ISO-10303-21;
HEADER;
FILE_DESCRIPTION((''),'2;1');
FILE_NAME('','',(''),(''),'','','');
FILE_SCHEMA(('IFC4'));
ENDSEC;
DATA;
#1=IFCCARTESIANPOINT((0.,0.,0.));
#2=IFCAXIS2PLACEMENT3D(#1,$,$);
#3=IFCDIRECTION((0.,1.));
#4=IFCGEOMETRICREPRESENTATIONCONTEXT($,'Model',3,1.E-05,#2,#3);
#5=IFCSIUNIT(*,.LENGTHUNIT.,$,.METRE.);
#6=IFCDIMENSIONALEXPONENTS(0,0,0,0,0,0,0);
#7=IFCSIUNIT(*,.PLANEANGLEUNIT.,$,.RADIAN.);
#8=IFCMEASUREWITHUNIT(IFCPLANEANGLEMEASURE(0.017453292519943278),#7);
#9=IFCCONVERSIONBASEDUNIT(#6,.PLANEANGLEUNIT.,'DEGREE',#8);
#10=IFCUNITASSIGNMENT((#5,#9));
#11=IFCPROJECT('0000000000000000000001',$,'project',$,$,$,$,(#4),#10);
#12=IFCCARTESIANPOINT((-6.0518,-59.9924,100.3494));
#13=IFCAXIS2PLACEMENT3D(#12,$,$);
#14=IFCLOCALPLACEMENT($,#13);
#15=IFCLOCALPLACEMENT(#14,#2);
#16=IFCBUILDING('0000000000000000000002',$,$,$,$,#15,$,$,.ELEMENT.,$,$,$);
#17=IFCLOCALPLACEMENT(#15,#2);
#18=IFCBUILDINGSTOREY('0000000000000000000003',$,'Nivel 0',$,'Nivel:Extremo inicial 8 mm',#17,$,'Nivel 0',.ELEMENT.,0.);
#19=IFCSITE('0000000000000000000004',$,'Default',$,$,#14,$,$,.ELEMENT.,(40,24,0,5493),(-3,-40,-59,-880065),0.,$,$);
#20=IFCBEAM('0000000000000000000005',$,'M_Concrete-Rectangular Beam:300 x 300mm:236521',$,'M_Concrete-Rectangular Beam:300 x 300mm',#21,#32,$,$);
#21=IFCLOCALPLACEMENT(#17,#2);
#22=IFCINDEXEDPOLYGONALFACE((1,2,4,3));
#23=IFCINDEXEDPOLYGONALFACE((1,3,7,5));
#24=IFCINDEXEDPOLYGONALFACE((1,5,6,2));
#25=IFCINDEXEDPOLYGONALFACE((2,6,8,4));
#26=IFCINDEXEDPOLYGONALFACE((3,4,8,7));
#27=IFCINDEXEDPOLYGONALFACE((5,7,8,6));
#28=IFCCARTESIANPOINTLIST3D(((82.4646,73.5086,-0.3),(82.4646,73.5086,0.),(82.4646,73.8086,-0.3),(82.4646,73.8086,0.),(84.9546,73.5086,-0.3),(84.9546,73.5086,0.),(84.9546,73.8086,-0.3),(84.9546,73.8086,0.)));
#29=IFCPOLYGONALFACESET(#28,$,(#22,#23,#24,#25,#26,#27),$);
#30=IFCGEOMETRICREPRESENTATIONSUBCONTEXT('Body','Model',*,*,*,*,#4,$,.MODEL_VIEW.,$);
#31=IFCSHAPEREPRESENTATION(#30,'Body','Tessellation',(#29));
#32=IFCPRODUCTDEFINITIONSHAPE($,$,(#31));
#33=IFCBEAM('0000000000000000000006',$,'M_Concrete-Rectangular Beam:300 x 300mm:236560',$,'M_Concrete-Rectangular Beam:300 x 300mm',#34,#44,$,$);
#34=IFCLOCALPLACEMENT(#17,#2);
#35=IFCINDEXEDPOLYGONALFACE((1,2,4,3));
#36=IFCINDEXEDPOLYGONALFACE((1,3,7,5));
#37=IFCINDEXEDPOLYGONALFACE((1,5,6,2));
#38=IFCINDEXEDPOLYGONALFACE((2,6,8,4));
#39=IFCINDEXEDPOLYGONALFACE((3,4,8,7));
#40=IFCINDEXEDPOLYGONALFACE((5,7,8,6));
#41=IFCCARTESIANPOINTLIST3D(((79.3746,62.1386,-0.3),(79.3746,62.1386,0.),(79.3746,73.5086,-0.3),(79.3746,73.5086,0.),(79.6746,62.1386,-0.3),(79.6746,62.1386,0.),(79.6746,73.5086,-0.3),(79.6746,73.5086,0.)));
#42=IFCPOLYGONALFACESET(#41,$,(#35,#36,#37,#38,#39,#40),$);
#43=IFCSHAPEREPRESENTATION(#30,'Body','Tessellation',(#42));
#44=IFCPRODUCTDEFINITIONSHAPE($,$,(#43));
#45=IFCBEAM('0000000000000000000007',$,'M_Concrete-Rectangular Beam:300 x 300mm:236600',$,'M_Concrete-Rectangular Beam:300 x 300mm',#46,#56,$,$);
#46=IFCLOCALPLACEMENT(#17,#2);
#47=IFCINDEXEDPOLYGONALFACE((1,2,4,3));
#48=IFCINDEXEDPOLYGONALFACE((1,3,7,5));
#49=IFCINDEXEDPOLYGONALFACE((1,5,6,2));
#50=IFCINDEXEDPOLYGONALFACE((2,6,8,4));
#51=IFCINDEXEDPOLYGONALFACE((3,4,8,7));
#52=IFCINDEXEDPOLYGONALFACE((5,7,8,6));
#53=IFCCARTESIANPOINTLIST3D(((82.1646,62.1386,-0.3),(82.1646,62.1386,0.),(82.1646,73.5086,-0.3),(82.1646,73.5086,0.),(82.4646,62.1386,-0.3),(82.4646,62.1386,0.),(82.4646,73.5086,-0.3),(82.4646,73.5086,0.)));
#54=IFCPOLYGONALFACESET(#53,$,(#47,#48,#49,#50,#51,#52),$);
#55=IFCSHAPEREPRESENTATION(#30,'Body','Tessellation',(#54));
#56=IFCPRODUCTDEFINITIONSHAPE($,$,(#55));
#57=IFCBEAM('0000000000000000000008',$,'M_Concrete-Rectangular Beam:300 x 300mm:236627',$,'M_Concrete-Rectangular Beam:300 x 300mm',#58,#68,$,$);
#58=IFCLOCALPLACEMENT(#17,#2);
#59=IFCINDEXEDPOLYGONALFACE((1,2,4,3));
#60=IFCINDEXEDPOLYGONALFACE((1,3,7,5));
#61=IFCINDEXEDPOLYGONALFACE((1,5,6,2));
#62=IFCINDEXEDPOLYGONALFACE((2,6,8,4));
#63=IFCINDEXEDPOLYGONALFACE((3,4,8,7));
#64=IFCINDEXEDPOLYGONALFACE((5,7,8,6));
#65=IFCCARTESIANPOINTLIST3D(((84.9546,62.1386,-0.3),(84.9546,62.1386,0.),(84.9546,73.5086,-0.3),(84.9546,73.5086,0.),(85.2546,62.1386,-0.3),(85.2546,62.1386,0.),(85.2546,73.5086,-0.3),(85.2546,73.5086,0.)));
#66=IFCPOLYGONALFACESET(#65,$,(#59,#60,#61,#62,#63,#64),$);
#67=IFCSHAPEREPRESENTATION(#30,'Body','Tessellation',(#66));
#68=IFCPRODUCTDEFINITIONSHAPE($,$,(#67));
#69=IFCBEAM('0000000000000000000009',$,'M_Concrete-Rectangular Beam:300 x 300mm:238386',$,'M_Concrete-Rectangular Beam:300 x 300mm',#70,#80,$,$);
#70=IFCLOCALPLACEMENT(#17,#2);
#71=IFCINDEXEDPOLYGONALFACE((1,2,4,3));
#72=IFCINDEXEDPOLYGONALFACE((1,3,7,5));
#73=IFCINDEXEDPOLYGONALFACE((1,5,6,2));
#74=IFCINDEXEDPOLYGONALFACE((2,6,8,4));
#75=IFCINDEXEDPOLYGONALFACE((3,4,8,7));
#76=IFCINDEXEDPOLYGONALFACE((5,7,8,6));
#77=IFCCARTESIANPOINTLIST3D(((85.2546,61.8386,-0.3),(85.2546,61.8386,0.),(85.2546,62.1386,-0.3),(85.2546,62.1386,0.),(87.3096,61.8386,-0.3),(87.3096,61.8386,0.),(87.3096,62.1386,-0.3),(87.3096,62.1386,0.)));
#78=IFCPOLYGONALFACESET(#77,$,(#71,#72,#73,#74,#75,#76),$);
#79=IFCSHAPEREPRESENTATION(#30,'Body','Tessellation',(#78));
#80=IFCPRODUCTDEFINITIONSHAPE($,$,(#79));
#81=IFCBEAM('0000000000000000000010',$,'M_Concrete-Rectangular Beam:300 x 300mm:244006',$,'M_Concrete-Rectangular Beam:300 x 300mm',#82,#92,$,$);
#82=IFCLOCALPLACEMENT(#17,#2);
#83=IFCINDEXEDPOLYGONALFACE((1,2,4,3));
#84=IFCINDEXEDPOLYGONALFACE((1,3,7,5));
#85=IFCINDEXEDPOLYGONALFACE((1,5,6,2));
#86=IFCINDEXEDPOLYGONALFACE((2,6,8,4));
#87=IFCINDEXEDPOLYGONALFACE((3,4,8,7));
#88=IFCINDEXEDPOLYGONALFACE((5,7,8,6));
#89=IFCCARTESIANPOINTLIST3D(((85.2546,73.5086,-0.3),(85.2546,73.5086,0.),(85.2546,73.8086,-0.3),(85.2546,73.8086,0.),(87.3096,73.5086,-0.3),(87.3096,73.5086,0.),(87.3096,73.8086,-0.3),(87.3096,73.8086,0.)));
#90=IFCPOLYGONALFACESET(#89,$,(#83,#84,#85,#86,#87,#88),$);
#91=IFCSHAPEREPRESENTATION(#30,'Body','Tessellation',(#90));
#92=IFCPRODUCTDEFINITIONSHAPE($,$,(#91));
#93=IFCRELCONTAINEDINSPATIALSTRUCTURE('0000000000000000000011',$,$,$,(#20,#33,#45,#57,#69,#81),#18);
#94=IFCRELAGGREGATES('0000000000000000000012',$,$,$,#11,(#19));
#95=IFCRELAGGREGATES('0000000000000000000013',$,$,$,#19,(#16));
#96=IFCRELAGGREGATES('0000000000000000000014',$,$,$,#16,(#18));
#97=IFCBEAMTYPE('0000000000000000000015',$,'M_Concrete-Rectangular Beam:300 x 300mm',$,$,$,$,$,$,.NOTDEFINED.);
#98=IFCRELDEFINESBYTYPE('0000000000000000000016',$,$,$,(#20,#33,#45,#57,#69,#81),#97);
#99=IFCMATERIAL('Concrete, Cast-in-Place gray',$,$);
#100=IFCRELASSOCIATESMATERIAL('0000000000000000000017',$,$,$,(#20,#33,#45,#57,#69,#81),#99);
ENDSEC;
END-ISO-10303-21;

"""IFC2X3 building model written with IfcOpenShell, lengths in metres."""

from ifc_helpers import new_model, entity, si_unit, converted_unit, direction, frame, frame_2d, origin, place, context, subcontext, project, spatial, rectangle, extrude, material, type_object, element, save


model = new_model("IFC2X3")

# Units and contexts
model_context = context("Model", 3, precision=1e-05, world=origin(), true_north=direction((0.0, 1.0)))
body_context = subcontext(model_context, "Body", "Model", "MODEL_VIEW")
ifc_project = project(units=[si_unit("LENGTHUNIT", "METRE"), converted_unit("PLANEANGLEUNIT", "DEGREE", entity("IfcPlaneAngleMeasure", 0.017453292519943278), si_unit("PLANEANGLEUNIT", "RADIAN"), dimensions=[0, 0, 0, 0, 0, 0, 0])], contexts=[model_context])

# Site, building, storey
site_placement = place(None, frame((-6.0518, -59.9924, 100.3494)))
site = spatial("IfcSite", under=ifc_project, at=site_placement, Name="Default", CompositionType="ELEMENT", RefLatitude=(40, 24, 0, 5493), RefLongitude=(-3, -40, -59, -880065), RefElevation=0.0)
building_placement = place(site_placement, origin())
building = spatial("IfcBuilding", under=site, at=building_placement, CompositionType="ELEMENT")
storey_placement = place(building_placement, origin())
storey = spatial("IfcBuildingStorey", under=building, at=storey_placement, Name="Nivel 0", ObjectType="Nivel:Extremo inicial 8 mm", LongName="Nivel 0", CompositionType="ELEMENT", Elevation=0.0)

# Shared definitions
ifc_material = material(Name="Concrete, Cast-in-Place gray")

# Beams
beam_type = type_object("IfcBeamType", Name="M_Concrete-Rectangular Beam:300 x 300mm", PredefinedType="NOTDEFINED")
for number, where, name in (
    (1, (82.3146, 73.6586, 0.0), "M_Concrete-Rectangular Beam:300 x 300mm:236521"),
):
    element("IfcBeam", number, at=place(storey_placement, frame(where)), inside=storey, type_object=beam_type, material=ifc_material, Name=name, ObjectType="M_Concrete-Rectangular Beam:300 x 300mm", context=body_context, shape_type="SweptSolid", body=[
        extrude(rectangle(XDim=0.3, YDim=0.3, at=frame_2d((0.0, 0.0), x_axis=(1.0, 0.0))), frame((0.15, 0.0, -0.15), z_axis=(1.0, 0.0, 0.0), x_axis=(0.0, 0.0, -1.0)), (0.0, 0.0, 1.0), 2.49),
    ])
beam_1_placement = place(storey_placement, frame((79.5246, 73.6586, 0.0), z_axis=(0.0, 0.0, 1.0), x_axis=(0.0, -1.0, 0.0)))
element("IfcBeam", 2, at=beam_1_placement, inside=storey, type_object=beam_type, material=ifc_material, Name="M_Concrete-Rectangular Beam:300 x 300mm:236560", ObjectType="M_Concrete-Rectangular Beam:300 x 300mm", context=body_context, shape_type="SweptSolid", body=[
    extrude(rectangle(XDim=0.3, YDim=0.3, at=frame_2d((0.0, 0.0), x_axis=(1.0, 0.0))), frame((0.15, 0.0, -0.15), z_axis=(1.0, 0.0, 0.0), x_axis=(0.0, 0.0, -1.0)), (0.0, 0.0, 1.0), 11.37),
])
beam_2_placement = place(storey_placement, frame((82.3146, 61.9886, 0.0), z_axis=(0.0, 0.0, 1.0), x_axis=(0.0, 1.0, 0.0)))
element("IfcBeam", 3, at=beam_2_placement, inside=storey, type_object=beam_type, material=ifc_material, Name="M_Concrete-Rectangular Beam:300 x 300mm:236600", ObjectType="M_Concrete-Rectangular Beam:300 x 300mm", context=body_context, shape_type="SweptSolid", body=[
    extrude(rectangle(XDim=0.3, YDim=0.3, at=frame_2d((0.0, 0.0), x_axis=(1.0, 0.0))), frame((0.15, 0.0, -0.15), z_axis=(1.0, 0.0, 0.0), x_axis=(0.0, 0.0, -1.0)), (0.0, 0.0, 1.0), 11.37),
])
beam_3_placement = place(storey_placement, frame((85.1046, 73.6586, 0.0), z_axis=(0.0, 0.0, 1.0), x_axis=(0.0, -1.0, 0.0)))
element("IfcBeam", 4, at=beam_3_placement, inside=storey, type_object=beam_type, material=ifc_material, Name="M_Concrete-Rectangular Beam:300 x 300mm:236627", ObjectType="M_Concrete-Rectangular Beam:300 x 300mm", context=body_context, shape_type="SweptSolid", body=[
    extrude(rectangle(XDim=0.3, YDim=0.3, at=frame_2d((0.0, 0.0), x_axis=(1.0, 0.0))), frame((0.15, 0.0, -0.15), z_axis=(1.0, 0.0, 0.0), x_axis=(0.0, 0.0, -1.0)), (0.0, 0.0, 1.0), 11.37),
])
beam_4_placement = place(storey_placement, frame((85.1046, 61.9886, 0.0)))
element("IfcBeam", 5, at=beam_4_placement, inside=storey, type_object=beam_type, material=ifc_material, Name="M_Concrete-Rectangular Beam:300 x 300mm:238386", ObjectType="M_Concrete-Rectangular Beam:300 x 300mm", context=body_context, shape_type="SweptSolid", body=[
    extrude(rectangle(XDim=0.3, YDim=0.3, at=frame_2d((0.0, 0.0), x_axis=(1.0, 0.0))), frame((0.15, 0.0, -0.15), z_axis=(1.0, 0.0, 0.0), x_axis=(0.0, 0.0, -1.0)), (0.0, 0.0, 1.0), 2.055),
])
beam_5_placement = place(storey_placement, frame((85.1046, 73.6586, 0.0)))
element("IfcBeam", 6, at=beam_5_placement, inside=storey, type_object=beam_type, material=ifc_material, Name="M_Concrete-Rectangular Beam:300 x 300mm:244006", ObjectType="M_Concrete-Rectangular Beam:300 x 300mm", context=body_context, shape_type="SweptSolid", body=[
    extrude(rectangle(XDim=0.3, YDim=0.3, at=frame_2d((0.0, 0.0), x_axis=(1.0, 0.0))), frame((0.15, 0.0, -0.15), z_axis=(1.0, 0.0, 0.0), x_axis=(0.0, 0.0, -1.0)), (0.0, 0.0, 1.0), 2.055),
])

save(model, "model.ifc")
